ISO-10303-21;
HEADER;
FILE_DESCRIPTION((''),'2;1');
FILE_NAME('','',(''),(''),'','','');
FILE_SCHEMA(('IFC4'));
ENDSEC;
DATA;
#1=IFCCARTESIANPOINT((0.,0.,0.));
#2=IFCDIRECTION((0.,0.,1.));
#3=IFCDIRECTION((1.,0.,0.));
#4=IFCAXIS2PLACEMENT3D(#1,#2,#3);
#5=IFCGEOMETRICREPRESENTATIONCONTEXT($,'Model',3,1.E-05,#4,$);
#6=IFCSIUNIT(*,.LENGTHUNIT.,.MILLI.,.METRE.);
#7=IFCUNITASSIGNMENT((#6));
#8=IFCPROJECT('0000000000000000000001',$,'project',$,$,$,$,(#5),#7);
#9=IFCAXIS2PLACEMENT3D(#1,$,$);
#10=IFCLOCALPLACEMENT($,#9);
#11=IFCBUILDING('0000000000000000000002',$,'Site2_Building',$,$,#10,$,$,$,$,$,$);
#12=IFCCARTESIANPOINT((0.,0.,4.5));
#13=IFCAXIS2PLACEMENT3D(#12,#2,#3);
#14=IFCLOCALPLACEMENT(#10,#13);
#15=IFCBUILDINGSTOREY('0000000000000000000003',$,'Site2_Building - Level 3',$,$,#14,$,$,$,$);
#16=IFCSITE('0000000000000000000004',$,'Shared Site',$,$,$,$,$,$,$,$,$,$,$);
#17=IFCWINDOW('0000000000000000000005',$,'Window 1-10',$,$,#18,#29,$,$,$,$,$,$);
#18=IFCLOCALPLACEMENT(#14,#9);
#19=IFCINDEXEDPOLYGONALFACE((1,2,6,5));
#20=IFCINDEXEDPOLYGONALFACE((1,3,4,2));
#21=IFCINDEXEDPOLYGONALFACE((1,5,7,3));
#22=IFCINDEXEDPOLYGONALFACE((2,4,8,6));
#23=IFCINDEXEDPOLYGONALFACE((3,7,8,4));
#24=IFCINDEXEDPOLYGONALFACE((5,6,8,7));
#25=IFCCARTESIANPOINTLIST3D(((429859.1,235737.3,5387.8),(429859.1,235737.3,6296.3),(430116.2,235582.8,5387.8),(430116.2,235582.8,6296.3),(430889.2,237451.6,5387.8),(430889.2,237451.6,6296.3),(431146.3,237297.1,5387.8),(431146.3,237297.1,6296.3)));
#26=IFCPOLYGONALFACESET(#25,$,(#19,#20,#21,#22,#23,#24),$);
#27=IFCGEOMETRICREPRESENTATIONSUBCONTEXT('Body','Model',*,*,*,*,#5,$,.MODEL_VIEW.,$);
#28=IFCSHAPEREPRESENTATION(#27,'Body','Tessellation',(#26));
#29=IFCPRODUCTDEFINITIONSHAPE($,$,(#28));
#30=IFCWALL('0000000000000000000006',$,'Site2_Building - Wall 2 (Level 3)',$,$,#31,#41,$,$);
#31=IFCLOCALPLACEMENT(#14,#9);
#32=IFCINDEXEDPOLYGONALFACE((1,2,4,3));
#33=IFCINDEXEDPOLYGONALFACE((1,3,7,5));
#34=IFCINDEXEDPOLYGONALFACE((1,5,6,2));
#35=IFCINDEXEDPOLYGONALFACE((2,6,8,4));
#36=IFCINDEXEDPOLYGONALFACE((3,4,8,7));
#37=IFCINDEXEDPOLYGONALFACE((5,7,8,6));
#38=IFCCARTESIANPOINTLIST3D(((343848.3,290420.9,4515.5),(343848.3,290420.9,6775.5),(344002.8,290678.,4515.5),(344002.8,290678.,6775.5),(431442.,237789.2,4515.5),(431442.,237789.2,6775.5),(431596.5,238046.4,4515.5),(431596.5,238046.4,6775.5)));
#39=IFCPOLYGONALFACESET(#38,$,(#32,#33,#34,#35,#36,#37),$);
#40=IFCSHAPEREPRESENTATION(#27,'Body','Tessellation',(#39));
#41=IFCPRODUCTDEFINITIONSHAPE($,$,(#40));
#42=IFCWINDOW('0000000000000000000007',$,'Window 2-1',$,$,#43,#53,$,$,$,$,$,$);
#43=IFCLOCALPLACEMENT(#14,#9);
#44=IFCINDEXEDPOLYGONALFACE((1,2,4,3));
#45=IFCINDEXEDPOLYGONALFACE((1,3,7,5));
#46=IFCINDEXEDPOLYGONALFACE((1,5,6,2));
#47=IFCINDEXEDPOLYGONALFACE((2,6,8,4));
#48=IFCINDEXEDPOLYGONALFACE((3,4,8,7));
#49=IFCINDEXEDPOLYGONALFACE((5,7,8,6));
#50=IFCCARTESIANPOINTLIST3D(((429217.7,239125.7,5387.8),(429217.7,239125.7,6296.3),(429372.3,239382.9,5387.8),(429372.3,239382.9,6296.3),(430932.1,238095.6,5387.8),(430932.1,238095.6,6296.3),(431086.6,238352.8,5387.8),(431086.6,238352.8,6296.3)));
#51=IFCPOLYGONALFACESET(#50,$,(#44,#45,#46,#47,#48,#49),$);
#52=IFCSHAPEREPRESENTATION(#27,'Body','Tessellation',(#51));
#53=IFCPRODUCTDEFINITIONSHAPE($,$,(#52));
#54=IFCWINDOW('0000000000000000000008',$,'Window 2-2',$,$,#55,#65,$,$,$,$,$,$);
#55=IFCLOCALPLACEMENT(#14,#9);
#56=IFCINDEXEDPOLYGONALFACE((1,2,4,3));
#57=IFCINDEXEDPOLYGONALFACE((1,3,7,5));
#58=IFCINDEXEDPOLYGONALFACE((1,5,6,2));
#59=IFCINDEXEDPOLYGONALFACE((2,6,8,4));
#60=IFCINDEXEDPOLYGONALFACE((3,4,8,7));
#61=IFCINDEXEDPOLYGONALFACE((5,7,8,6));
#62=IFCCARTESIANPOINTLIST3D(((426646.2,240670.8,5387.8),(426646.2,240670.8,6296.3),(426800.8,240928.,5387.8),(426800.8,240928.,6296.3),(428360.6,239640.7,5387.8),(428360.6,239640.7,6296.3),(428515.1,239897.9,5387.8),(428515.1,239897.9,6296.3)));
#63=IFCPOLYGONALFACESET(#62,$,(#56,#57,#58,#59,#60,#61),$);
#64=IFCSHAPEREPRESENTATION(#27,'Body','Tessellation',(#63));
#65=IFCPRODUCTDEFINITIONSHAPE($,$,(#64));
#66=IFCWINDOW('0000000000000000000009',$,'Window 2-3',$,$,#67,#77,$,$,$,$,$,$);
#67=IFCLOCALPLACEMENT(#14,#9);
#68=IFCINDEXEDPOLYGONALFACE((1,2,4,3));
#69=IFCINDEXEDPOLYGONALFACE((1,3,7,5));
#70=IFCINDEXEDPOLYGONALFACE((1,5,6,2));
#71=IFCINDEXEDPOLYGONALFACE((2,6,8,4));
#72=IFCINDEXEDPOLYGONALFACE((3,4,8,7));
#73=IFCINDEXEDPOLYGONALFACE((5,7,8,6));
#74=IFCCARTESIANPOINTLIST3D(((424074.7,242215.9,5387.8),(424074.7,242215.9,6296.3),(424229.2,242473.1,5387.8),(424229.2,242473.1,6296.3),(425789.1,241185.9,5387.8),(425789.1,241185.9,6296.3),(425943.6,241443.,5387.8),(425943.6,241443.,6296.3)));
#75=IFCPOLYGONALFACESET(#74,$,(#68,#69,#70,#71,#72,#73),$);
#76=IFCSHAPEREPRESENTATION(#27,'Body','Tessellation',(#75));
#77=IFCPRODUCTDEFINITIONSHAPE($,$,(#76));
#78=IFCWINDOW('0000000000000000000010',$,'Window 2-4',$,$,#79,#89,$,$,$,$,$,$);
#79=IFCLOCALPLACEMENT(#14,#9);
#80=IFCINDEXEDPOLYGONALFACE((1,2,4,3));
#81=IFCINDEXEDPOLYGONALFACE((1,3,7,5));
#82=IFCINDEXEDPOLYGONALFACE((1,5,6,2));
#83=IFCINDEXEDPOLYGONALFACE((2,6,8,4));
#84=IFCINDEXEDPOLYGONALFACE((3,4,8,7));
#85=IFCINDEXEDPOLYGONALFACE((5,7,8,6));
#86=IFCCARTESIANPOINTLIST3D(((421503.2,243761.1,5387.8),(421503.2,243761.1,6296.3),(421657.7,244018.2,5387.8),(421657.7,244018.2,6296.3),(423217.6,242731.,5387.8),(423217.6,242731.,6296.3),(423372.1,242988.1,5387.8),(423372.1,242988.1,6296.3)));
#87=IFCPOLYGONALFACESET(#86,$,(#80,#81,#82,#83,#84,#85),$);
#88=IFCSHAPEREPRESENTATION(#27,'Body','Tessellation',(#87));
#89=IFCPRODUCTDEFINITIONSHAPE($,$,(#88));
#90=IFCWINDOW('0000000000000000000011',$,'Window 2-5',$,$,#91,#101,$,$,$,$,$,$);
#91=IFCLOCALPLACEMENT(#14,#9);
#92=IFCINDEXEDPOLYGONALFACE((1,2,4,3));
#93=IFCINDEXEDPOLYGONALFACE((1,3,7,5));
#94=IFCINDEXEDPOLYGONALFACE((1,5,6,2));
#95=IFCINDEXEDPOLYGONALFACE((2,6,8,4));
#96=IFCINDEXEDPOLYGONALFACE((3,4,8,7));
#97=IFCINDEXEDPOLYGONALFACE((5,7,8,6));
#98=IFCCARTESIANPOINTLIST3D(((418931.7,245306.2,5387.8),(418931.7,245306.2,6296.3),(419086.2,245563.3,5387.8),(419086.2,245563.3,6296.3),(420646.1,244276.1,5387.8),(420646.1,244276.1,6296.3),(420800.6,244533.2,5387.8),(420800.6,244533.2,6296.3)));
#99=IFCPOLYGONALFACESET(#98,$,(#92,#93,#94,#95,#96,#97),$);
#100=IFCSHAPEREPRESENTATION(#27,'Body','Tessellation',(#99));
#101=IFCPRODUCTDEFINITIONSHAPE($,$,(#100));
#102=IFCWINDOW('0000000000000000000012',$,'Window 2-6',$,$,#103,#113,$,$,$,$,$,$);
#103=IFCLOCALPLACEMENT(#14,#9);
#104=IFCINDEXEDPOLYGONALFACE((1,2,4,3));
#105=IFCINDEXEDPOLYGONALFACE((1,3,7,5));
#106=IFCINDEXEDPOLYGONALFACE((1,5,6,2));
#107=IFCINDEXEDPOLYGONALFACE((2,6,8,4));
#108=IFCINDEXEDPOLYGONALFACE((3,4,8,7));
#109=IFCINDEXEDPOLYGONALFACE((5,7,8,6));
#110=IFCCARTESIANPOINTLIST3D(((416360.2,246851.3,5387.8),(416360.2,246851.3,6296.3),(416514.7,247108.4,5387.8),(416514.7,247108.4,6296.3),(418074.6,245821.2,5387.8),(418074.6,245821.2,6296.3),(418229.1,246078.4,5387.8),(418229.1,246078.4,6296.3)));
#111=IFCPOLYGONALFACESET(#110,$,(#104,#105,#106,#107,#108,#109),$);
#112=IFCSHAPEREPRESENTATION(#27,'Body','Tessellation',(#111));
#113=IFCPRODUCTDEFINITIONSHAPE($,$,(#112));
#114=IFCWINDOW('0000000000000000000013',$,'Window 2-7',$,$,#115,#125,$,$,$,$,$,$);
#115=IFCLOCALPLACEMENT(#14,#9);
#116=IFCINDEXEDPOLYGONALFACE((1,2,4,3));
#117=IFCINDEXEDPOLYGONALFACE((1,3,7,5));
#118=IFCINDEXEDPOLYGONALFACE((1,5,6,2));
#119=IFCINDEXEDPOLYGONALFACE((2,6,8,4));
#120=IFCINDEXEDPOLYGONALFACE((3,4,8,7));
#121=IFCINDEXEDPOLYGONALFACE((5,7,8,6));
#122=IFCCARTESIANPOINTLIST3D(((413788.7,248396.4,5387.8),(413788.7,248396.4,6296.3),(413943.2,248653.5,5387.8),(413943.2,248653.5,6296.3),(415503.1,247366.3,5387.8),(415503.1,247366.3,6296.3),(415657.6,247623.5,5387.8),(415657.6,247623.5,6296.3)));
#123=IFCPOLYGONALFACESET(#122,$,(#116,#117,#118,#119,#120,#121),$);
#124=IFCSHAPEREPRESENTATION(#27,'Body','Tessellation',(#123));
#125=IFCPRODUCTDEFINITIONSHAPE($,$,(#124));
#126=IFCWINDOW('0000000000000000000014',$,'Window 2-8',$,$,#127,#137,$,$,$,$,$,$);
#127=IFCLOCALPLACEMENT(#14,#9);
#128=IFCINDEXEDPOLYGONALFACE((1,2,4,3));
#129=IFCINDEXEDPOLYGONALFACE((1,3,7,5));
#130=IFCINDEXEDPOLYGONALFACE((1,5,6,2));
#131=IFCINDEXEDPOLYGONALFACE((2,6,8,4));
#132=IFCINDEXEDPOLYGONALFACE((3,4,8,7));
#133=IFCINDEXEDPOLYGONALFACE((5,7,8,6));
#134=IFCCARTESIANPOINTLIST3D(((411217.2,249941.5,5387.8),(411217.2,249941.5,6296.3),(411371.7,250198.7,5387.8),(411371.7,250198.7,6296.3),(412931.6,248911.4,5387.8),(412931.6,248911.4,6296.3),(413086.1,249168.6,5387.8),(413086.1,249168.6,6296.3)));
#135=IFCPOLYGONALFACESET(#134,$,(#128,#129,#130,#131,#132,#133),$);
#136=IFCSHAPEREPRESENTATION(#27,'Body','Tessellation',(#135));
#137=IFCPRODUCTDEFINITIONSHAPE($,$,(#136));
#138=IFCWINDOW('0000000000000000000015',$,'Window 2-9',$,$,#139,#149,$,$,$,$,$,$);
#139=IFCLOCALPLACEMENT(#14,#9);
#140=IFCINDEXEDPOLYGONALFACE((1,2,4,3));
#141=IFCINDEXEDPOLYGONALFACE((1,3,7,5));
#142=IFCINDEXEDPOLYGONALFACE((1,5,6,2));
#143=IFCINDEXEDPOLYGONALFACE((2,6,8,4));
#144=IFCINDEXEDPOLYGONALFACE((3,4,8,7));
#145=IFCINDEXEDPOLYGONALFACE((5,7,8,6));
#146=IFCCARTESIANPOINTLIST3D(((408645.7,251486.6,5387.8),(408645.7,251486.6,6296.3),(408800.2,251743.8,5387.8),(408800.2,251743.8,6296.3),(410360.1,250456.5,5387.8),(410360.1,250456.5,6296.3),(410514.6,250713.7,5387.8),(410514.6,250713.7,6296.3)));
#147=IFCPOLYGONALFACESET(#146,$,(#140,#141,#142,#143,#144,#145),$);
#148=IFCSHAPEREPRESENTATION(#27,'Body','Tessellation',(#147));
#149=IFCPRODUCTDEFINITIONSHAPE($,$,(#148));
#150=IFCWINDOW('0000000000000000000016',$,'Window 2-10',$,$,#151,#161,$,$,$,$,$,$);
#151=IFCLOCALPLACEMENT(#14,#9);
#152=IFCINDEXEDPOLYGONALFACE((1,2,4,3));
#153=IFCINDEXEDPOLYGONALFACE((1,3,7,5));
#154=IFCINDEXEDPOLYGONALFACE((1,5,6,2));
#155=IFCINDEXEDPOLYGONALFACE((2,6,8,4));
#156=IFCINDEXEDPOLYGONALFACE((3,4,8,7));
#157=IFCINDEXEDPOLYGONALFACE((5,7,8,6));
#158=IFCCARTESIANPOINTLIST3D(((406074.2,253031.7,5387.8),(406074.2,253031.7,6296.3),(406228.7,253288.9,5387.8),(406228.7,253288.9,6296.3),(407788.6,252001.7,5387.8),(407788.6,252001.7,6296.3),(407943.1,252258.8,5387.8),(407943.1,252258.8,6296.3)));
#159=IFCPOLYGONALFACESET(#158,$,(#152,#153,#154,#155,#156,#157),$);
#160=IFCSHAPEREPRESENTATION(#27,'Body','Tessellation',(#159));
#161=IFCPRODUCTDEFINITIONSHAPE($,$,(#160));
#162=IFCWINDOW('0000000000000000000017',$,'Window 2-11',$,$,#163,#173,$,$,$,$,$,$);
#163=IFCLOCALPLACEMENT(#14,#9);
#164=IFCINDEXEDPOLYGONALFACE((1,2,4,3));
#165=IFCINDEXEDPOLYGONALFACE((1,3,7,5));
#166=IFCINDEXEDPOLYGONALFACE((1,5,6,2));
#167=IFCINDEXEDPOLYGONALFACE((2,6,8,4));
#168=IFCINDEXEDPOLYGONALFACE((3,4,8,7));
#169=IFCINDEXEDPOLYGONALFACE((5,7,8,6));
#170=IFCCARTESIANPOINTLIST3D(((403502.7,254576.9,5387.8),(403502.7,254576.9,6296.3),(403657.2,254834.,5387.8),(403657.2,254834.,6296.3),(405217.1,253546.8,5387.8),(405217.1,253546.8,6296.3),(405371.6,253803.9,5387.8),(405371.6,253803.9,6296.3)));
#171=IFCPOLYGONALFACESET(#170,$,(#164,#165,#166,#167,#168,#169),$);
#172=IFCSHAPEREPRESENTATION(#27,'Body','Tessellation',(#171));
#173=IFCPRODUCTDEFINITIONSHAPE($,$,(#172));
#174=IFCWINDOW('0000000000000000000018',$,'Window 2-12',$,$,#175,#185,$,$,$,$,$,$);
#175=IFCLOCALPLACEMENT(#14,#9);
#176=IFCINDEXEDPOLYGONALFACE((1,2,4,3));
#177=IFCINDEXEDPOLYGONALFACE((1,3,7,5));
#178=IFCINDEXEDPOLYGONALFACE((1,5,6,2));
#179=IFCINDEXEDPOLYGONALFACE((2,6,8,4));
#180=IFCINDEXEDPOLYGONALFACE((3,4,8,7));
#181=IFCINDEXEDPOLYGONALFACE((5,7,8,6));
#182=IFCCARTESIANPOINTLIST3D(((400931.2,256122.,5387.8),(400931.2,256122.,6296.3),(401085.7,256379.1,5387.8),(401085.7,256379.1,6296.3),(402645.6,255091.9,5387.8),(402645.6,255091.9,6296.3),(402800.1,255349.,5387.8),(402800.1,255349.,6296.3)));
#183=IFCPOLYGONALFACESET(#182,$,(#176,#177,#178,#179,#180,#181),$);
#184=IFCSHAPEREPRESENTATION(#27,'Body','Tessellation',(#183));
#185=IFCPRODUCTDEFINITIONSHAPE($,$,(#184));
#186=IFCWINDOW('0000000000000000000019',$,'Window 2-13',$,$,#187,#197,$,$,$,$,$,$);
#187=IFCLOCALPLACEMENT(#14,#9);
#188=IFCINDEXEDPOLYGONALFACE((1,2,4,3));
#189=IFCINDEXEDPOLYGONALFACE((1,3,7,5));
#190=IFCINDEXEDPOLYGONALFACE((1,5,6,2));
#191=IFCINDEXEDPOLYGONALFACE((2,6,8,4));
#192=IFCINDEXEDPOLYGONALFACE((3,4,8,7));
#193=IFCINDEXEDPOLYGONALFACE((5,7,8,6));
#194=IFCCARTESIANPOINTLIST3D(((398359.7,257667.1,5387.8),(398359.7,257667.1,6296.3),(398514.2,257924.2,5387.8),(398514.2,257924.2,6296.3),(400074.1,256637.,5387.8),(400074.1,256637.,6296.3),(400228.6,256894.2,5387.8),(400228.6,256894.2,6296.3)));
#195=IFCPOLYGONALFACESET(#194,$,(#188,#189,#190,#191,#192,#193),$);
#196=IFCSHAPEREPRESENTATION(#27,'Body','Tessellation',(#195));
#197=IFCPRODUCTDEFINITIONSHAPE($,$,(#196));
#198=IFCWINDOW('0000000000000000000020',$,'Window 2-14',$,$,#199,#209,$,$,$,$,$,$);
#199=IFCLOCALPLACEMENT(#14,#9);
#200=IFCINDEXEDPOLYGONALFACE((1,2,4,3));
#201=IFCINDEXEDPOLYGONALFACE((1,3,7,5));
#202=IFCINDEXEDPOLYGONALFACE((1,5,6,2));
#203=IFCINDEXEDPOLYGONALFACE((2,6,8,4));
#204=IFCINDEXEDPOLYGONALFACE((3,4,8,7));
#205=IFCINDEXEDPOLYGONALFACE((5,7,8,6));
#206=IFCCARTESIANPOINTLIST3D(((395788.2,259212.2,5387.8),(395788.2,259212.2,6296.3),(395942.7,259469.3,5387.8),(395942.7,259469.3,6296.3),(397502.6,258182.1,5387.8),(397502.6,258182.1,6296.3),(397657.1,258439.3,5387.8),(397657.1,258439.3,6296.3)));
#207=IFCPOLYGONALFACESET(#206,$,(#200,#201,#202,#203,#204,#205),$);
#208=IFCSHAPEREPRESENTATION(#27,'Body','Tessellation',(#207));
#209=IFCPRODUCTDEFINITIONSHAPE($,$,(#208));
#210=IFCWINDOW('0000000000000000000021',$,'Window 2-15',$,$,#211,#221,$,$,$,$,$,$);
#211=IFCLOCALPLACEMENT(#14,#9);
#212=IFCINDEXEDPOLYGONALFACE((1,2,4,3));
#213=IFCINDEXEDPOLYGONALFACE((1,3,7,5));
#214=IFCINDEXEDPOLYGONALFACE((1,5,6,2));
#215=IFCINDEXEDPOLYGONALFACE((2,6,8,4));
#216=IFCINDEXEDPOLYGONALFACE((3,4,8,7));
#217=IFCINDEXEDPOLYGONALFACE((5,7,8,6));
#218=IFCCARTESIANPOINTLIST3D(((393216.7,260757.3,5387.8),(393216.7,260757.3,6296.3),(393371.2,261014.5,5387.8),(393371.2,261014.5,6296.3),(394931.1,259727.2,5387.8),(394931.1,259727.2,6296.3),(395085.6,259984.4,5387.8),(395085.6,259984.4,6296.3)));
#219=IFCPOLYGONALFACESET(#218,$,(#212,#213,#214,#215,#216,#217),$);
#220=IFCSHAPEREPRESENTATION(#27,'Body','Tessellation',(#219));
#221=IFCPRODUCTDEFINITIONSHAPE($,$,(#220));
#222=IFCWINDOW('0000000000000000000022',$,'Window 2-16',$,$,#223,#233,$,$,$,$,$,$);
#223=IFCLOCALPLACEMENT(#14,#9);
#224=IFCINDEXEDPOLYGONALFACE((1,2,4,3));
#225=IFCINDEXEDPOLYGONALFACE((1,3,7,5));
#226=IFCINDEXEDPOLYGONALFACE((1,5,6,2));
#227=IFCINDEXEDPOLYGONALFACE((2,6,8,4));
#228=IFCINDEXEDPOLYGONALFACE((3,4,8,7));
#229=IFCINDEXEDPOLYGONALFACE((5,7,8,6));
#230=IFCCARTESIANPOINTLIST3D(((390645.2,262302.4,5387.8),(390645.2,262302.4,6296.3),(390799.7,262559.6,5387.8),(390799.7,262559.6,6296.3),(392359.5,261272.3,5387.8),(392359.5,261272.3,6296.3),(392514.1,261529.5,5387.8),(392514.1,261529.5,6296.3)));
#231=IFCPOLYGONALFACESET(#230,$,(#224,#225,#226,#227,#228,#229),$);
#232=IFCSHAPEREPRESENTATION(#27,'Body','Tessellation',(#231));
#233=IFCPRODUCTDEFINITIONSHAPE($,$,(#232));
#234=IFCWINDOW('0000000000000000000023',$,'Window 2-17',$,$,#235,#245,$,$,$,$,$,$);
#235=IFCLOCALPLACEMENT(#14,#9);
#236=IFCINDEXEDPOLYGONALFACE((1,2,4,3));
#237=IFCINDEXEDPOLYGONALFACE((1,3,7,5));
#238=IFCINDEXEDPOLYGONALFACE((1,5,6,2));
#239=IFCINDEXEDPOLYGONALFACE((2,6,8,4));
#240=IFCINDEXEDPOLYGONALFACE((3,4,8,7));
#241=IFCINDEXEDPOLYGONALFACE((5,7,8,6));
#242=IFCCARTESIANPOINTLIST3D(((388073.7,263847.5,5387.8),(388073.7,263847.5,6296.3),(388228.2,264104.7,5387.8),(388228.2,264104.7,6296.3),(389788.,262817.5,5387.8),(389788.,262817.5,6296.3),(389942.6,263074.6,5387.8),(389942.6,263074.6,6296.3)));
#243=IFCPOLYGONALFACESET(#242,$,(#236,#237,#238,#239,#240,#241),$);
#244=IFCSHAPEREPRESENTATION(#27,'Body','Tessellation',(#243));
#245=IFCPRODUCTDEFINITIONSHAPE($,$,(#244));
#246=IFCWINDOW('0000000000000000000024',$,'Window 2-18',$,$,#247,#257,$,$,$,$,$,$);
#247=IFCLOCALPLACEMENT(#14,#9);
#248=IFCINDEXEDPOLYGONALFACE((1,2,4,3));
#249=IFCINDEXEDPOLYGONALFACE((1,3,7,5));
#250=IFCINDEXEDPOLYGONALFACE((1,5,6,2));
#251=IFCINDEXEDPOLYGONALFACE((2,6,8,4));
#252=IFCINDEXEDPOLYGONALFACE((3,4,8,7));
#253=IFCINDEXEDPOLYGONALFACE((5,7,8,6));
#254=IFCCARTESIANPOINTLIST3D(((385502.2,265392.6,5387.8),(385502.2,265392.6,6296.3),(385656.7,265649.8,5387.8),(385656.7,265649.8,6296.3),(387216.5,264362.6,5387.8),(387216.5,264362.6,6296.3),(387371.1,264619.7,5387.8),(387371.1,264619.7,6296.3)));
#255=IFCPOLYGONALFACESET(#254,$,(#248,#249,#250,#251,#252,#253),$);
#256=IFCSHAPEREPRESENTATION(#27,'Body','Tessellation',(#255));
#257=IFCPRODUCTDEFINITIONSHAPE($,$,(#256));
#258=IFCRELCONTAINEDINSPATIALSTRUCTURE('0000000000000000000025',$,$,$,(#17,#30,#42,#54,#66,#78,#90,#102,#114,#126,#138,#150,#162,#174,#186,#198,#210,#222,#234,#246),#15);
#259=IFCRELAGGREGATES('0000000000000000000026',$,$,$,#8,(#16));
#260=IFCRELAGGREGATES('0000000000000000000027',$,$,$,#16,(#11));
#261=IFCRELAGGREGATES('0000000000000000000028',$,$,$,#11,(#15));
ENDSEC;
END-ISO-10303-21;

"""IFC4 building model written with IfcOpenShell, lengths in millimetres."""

from ifc_helpers import new_model, si_unit, frame, origin, origin_with_axes, place, context, subcontext, project, spatial, indexed_curve, outline, extrude, element, save


model = new_model("IFC4")

# Units and contexts
model_context = context("Model", 3, precision=1e-05, world=origin_with_axes())
body_context = subcontext(model_context, "Body", "Model", "MODEL_VIEW")
ifc_project = project(units=[si_unit("LENGTHUNIT", "METRE", prefix="MILLI")], contexts=[model_context])

# Site, building, storey
site = spatial("IfcSite", under=ifc_project, Name="Shared Site")
building_placement = place(None, origin())
building = spatial("IfcBuilding", under=site, at=building_placement, Name="Site2_Building")
storey_placement = place(building_placement, frame((0.0, 0.0, 4.5), z_axis=(0.0, 0.0, 1.0), x_axis=(1.0, 0.0, 0.0)))
storey = spatial("IfcBuildingStorey", under=building, at=storey_placement, Name="Site2_Building - Level 3")

# Window
window_placement = place(storey_placement, frame((430116.2, 235582.8, 5387.8), z_axis=(0.0, 0.0, 1.0), x_axis=(0.515038, 0.857167, 0.0)))
element("IfcWindow", 1, at=window_placement, inside=storey, Name="Window 1-10", context=body_context, shape_type="SweptSolid", body=[
    extrude(outline(indexed_curve([(0.0, 0.0), (0.0, 300.0), (2000.0, 300.0), (2000.0, 0.0), (0.0, 0.0)], self_intersect=False)), origin_with_axes(), (0.0, 0.0, 1.0), 908.6),
])

# Wall
wall_placement = place(storey_placement, frame((431596.5, 238046.4, 4515.5), z_axis=(0.0, 0.0, 1.0), x_axis=(-0.857167, 0.515038, 0.0)))
element("IfcWall", 2, at=wall_placement, inside=storey, Name="Site2_Building - Wall 2 (Level 3)", context=body_context, shape_type="SweptSolid", body=[
    extrude(outline(indexed_curve([(0.0, 0.0), (0.0, 300.0), (102189.8, 300.0), (102189.8, 0.0), (0.0, 0.0)], self_intersect=False)), origin_with_axes(), (0.0, 0.0, 1.0), 2260.0),
])

# Windows
for number, where, z_axis, x_axis, name in (
    (3, (431086.6, 238352.8, 5387.8), (0.0, 0.0, 1.0), (-0.857167, 0.515038, 0.0), "Window 2-1"),
    (4, (428515.1, 239897.9, 5387.8), (0.0, 0.0, 1.0), (-0.857167, 0.515038, 0.0), "Window 2-2"),
    (5, (425943.6, 241443.0, 5387.8), (0.0, 0.0, 1.0), (-0.857167, 0.515038, 0.0), "Window 2-3"),
    (6, (423372.1, 242988.1, 5387.8), (0.0, 0.0, 1.0), (-0.857167, 0.515038, 0.0), "Window 2-4"),
    (7, (420800.6, 244533.2, 5387.8), (0.0, 0.0, 1.0), (-0.857167, 0.515038, 0.0), "Window 2-5"),
    (8, (418229.1, 246078.4, 5387.8), (0.0, 0.0, 1.0), (-0.857167, 0.515038, 0.0), "Window 2-6"),
    (9, (415657.6, 247623.5, 5387.8), (0.0, 0.0, 1.0), (-0.857167, 0.515038, 0.0), "Window 2-7"),
    (10, (413086.1, 249168.6, 5387.8), (0.0, 0.0, 1.0), (-0.857167, 0.515038, 0.0), "Window 2-8"),
    (11, (410514.6, 250713.7, 5387.8), (0.0, 0.0, 1.0), (-0.857167, 0.515038, 0.0), "Window 2-9"),
    (12, (407943.1, 252258.8, 5387.8), (0.0, 0.0, 1.0), (-0.857167, 0.515038, 0.0), "Window 2-10"),
    (13, (405371.6, 253803.9, 5387.8), (0.0, 0.0, 1.0), (-0.857167, 0.515038, 0.0), "Window 2-11"),
    (14, (402800.1, 255349.0, 5387.8), (0.0, 0.0, 1.0), (-0.857167, 0.515038, 0.0), "Window 2-12"),
    (15, (400228.6, 256894.2, 5387.8), (0.0, 0.0, 1.0), (-0.857167, 0.515038, 0.0), "Window 2-13"),
    (16, (397657.1, 258439.3, 5387.8), (0.0, 0.0, 1.0), (-0.857167, 0.515038, 0.0), "Window 2-14"),
    (17, (395085.6, 259984.4, 5387.8), (0.0, 0.0, 1.0), (-0.857167, 0.515038, 0.0), "Window 2-15"),
    (18, (392514.1, 261529.5, 5387.8), (0.0, 0.0, 1.0), (-0.857167, 0.515038, 0.0), "Window 2-16"),
    (19, (389942.6, 263074.6, 5387.8), (0.0, 0.0, 1.0), (-0.857167, 0.515038, 0.0), "Window 2-17"),
    (20, (387371.1, 264619.7, 5387.8), (0.0, 0.0, 1.0), (-0.857167, 0.515038, 0.0), "Window 2-18"),
):
    element("IfcWindow", number, at=place(storey_placement, frame(where, z_axis=z_axis, x_axis=x_axis)), inside=storey, Name=name, context=body_context, shape_type="SweptSolid", body=[
        extrude(outline(indexed_curve([(0.0, 0.0), (0.0, 300.0), (2000.0, 300.0), (2000.0, 0.0), (0.0, 0.0)], self_intersect=False)), origin_with_axes(), (0.0, 0.0, 1.0), 908.6),
    ])

save(model, "model.ifc")
